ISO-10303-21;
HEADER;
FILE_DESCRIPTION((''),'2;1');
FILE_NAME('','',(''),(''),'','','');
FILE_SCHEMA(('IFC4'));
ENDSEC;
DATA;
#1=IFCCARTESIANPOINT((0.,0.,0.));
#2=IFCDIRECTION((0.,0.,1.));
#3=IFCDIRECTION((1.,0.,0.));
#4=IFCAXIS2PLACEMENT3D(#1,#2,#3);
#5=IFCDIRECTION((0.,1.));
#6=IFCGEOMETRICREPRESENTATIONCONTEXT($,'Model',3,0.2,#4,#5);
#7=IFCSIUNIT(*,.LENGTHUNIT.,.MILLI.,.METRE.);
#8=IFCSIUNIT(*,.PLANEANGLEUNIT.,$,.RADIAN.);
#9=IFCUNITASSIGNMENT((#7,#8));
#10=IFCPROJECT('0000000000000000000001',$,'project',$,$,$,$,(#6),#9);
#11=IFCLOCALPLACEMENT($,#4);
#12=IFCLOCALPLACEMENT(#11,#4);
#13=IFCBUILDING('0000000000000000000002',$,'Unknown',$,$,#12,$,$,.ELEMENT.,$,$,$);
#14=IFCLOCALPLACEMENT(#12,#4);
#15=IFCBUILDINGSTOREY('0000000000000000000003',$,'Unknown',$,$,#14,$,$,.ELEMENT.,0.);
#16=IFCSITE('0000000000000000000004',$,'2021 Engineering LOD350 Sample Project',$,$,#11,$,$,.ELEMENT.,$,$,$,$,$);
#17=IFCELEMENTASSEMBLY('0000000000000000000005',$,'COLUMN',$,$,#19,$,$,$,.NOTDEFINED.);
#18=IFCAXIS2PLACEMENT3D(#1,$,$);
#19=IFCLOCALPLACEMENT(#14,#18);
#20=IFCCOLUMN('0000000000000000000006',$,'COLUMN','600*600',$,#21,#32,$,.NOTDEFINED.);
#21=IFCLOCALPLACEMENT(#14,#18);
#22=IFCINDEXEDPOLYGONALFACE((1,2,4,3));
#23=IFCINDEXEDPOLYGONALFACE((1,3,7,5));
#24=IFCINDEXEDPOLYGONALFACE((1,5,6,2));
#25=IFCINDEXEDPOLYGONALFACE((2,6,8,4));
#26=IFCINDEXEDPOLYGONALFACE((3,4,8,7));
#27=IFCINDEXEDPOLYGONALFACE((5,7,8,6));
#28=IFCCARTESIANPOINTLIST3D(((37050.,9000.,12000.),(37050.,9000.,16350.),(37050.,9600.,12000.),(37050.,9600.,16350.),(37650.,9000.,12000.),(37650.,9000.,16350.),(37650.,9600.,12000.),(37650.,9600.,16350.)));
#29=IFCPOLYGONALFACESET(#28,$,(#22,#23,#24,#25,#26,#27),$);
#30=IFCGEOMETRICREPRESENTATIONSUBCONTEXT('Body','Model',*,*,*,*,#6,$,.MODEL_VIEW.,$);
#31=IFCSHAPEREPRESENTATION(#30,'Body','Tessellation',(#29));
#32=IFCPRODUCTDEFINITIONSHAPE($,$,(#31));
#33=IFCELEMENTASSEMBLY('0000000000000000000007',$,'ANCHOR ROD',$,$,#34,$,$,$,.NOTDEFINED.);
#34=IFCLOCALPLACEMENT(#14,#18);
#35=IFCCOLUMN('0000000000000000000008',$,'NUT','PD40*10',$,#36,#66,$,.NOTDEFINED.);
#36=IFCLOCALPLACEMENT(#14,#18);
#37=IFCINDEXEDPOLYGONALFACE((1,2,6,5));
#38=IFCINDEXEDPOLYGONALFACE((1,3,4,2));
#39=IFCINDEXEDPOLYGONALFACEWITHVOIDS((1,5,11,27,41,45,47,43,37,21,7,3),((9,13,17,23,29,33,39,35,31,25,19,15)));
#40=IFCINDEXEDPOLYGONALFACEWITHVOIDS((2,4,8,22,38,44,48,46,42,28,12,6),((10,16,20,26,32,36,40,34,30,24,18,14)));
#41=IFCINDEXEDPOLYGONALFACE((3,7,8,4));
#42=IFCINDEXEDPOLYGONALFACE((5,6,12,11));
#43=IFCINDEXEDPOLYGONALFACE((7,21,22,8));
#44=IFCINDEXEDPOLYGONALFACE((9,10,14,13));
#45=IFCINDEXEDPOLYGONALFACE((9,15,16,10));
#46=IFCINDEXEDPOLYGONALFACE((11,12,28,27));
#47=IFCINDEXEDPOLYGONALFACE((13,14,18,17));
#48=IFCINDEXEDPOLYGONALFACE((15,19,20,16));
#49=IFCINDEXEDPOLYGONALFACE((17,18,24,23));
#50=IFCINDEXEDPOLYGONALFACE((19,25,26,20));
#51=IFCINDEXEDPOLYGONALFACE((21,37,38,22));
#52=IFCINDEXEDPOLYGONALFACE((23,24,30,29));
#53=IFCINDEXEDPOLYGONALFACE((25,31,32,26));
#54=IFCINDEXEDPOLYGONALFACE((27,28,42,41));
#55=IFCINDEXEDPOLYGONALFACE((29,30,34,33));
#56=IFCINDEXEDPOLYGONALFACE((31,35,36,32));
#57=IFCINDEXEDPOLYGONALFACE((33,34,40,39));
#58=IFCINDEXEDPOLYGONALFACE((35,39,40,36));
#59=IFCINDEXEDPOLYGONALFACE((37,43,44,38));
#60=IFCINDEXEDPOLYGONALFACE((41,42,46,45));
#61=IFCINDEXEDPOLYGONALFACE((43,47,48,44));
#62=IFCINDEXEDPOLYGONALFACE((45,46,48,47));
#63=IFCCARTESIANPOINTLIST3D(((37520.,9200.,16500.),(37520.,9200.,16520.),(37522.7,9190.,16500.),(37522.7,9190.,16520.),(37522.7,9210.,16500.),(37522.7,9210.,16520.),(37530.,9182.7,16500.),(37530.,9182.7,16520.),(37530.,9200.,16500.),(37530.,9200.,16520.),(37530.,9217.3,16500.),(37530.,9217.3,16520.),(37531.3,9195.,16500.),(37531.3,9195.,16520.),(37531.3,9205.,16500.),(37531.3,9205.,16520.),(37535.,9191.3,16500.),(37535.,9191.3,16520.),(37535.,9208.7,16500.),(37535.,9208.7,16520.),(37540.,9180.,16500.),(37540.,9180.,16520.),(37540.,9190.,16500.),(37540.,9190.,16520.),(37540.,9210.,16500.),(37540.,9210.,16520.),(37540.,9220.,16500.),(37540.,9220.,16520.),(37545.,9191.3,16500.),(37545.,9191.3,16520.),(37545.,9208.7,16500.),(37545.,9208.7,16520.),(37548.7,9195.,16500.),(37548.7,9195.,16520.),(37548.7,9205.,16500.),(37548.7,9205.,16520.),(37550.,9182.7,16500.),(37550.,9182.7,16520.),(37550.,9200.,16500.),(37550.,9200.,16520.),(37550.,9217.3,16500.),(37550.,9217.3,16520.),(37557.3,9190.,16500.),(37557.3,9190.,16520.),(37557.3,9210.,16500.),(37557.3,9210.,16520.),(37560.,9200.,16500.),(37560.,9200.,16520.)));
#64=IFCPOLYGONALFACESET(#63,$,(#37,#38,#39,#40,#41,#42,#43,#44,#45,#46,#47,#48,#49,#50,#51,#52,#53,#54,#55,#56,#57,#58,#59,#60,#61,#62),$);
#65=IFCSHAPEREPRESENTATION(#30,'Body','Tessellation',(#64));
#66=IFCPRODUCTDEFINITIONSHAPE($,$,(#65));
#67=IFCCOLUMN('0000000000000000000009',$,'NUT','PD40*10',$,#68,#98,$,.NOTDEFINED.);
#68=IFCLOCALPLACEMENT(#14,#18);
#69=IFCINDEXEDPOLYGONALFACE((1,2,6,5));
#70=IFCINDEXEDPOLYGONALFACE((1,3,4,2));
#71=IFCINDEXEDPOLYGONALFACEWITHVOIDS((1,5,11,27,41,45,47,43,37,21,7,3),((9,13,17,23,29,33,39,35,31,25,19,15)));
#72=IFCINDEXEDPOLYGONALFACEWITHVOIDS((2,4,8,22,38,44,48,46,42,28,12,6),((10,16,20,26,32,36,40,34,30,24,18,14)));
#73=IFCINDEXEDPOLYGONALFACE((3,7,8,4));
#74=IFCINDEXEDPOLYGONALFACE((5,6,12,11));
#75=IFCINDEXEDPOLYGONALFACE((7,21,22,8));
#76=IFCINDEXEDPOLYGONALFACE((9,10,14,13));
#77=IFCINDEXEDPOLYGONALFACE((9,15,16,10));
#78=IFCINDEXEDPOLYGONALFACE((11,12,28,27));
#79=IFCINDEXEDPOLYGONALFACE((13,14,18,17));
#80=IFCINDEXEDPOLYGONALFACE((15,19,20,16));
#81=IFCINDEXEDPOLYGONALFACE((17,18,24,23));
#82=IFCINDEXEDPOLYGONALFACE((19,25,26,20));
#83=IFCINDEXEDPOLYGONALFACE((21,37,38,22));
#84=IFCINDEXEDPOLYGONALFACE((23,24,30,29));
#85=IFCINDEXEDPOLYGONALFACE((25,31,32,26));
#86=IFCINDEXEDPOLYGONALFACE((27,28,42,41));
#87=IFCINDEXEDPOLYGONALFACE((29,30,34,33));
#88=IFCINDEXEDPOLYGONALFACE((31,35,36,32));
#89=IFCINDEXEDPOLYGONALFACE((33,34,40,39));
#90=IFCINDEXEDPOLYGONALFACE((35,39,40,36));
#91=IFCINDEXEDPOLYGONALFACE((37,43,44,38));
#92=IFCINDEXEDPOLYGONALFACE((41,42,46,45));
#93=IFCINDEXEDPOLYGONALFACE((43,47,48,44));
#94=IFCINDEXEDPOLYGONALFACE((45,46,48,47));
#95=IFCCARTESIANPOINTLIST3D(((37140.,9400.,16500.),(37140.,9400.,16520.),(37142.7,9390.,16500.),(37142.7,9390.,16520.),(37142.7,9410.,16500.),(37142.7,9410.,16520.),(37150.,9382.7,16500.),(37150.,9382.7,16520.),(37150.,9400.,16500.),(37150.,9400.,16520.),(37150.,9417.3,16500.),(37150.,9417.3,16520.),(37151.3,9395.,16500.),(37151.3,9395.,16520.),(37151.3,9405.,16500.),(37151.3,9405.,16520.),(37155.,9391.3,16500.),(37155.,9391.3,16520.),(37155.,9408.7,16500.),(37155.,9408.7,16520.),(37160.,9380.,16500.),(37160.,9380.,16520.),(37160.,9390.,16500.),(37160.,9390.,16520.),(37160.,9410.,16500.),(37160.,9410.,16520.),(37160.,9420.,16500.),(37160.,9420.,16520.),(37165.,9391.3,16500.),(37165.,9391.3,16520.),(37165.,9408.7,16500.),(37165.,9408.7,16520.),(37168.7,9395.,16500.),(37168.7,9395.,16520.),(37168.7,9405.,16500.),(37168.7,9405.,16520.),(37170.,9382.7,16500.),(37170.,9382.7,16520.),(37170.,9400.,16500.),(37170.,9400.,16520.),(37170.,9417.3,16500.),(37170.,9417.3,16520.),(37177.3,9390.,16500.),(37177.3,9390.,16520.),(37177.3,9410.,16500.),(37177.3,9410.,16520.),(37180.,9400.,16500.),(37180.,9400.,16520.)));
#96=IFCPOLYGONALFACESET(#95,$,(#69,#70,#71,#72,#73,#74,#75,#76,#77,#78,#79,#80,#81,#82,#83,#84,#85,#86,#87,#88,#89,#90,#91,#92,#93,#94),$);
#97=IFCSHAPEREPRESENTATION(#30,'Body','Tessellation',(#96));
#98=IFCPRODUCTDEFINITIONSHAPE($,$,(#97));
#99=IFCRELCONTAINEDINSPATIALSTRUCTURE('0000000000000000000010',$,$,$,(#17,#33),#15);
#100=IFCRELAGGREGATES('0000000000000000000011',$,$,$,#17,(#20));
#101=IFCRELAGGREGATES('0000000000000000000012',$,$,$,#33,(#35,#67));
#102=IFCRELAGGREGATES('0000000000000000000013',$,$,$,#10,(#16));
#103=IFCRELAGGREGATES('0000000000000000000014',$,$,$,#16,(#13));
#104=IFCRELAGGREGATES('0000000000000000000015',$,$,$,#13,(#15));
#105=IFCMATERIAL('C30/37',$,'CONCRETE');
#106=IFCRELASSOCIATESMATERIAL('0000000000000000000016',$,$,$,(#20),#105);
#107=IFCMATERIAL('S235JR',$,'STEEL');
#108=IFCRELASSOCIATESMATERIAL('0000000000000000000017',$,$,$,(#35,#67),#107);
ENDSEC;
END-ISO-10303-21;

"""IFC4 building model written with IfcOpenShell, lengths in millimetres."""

from ifc_helpers import new_model, si_unit, direction, frame, origin_with_axes, place, context, subcontext, project, spatial, line, indexed_curve, outline, extrude, material, element, aggregate, save


model = new_model("IFC4")

# Units and contexts
model_context = context("Model", 3, precision=0.2, world=origin_with_axes(), true_north=direction((0.0, 1.0)))
body_context = subcontext(model_context, "Body", "Model", "MODEL_VIEW")
ifc_project = project(units=[si_unit("LENGTHUNIT", "METRE", prefix="MILLI"), si_unit("PLANEANGLEUNIT", "RADIAN")], contexts=[model_context])

# Site, building, storey
site_placement = place(None, origin_with_axes())
site = spatial("IfcSite", under=ifc_project, at=site_placement, Name="2021 Engineering LOD350 Sample Project", CompositionType="ELEMENT")
building_placement = place(site_placement, origin_with_axes())
building = spatial("IfcBuilding", under=site, at=building_placement, Name="Unknown", CompositionType="ELEMENT")
storey_placement = place(building_placement, origin_with_axes())
storey = spatial("IfcBuildingStorey", under=building, at=storey_placement, Name="Unknown", CompositionType="ELEMENT", Elevation=0.0)

# Element assembly, column
assembly_1_placement = place(storey_placement, frame((37350.0, 9300.0, 12000.0), z_axis=(-1.0, 0.0, 0.0), x_axis=(0.0, 0.0, 1.0)))
assembly_1 = element("IfcElementAssembly", 1, at=assembly_1_placement, inside=storey, Name="COLUMN", PredefinedType="NOTDEFINED")
ifc_material_1 = material(Name="C30/37", Category="CONCRETE")
column_1_placement = place(assembly_1_placement, origin_with_axes())
column_1 = element("IfcColumn", 2, at=column_1_placement, material=ifc_material_1, Name="COLUMN", Description="600*600", PredefinedType="NOTDEFINED", context=body_context, shape_type="SolidModel", body=[
    extrude(outline(indexed_curve([(-300.0, -300.0), (300.0, -300.0), (300.0, 300.0), (-300.0, 300.0)], segments=[line(1, 2, 3, 4, 1)])), frame((0.0, 0.0, 0.0), z_axis=(-1.0, 0.0, 0.0), x_axis=(0.0, 0.0, 1.0)), (0.0, 0.0, -1.0), 4350.0),
])

# Element assembly, columns
assembly_2_placement = place(storey_placement, frame((37540.0, 9400.0, 16730.0), z_axis=(1.0, 0.0, 0.0), x_axis=(0.0, 0.0, -1.0)))
assembly_2 = element("IfcElementAssembly", 3, at=assembly_2_placement, inside=storey, Name="ANCHOR ROD", PredefinedType="NOTDEFINED")
ifc_material_2 = material(Name="S235JR", Category="STEEL")
column_2_placement = place(assembly_2_placement, frame((210.0, -200.0, 0.0), z_axis=(0.0, 0.0, 1.0), x_axis=(1.0, 0.0, 0.0)))
column_2 = element("IfcColumn", 4, at=column_2_placement, material=ifc_material_2, Name="NUT", Description="PD40*10", PredefinedType="NOTDEFINED", context=body_context, shape_type="SolidModel", body=[
    extrude(outline(indexed_curve([(20.0, 0.0), (17.3, 10.0), (10.0, 17.3), (0.0, 20.0), (-10.0, 17.3), (-17.3, 10.0), (-20.0, 0.0), (-17.3, -10.0), (-10.0, -17.3), (0.0, -20.0), (10.0, -17.3), (17.3, -10.0)], segments=[line(1, 2, 3, 4, 5, 6, 7, 8, 9, 10, 11, 12, 1)]), holes=[indexed_curve([(10.0, 0.0), (8.7, -5.0), (5.0, -8.7), (0.0, -10.0), (-5.0, -8.7), (-8.7, -5.0), (-10.0, 0.0), (-8.7, 5.0), (-5.0, 8.7), (0.0, 10.0), (5.0, 8.7), (8.7, 5.0)], segments=[line(1, 2, 3, 4, 5, 6, 7, 8, 9, 10, 11, 12, 1)])]), frame((0.0, 0.0, 0.0), z_axis=(-1.0, 0.0, 0.0), x_axis=(0.0, 0.0, 1.0)), (0.0, 0.0, -1.0), 20.0),
])
column_3_placement = place(assembly_2_placement, frame((210.0, 0.0, -380.0), z_axis=(0.0, 0.0, -1.0), x_axis=(1.0, 0.0, 0.0)))
column_3 = element("IfcColumn", 5, at=column_3_placement, material=ifc_material_2, Name="NUT", Description="PD40*10", PredefinedType="NOTDEFINED", context=body_context, shape_type="SolidModel", body=[
    extrude(outline(indexed_curve([(20.0, 0.0), (17.3, 10.0), (10.0, 17.3), (0.0, 20.0), (-10.0, 17.3), (-17.3, 10.0), (-20.0, 0.0), (-17.3, -10.0), (-10.0, -17.3), (0.0, -20.0), (10.0, -17.3), (17.3, -10.0)], segments=[line(1, 2, 3, 4, 5, 6, 7, 8, 9, 10, 11, 12, 1)]), holes=[indexed_curve([(10.0, 0.0), (8.7, -5.0), (5.0, -8.7), (0.0, -10.0), (-5.0, -8.7), (-8.7, -5.0), (-10.0, 0.0), (-8.7, 5.0), (-5.0, 8.7), (0.0, 10.0), (5.0, 8.7), (8.7, 5.0)], segments=[line(1, 2, 3, 4, 5, 6, 7, 8, 9, 10, 11, 12, 1)])]), frame((0.0, 0.0, 0.0), z_axis=(-1.0, 0.0, 0.0), x_axis=(0.0, 0.0, 1.0)), (0.0, 0.0, -1.0), 20.0),
])

aggregate(assembly_1, [column_1])

aggregate(assembly_2, [column_2, column_3])

save(model, "model.ifc")
